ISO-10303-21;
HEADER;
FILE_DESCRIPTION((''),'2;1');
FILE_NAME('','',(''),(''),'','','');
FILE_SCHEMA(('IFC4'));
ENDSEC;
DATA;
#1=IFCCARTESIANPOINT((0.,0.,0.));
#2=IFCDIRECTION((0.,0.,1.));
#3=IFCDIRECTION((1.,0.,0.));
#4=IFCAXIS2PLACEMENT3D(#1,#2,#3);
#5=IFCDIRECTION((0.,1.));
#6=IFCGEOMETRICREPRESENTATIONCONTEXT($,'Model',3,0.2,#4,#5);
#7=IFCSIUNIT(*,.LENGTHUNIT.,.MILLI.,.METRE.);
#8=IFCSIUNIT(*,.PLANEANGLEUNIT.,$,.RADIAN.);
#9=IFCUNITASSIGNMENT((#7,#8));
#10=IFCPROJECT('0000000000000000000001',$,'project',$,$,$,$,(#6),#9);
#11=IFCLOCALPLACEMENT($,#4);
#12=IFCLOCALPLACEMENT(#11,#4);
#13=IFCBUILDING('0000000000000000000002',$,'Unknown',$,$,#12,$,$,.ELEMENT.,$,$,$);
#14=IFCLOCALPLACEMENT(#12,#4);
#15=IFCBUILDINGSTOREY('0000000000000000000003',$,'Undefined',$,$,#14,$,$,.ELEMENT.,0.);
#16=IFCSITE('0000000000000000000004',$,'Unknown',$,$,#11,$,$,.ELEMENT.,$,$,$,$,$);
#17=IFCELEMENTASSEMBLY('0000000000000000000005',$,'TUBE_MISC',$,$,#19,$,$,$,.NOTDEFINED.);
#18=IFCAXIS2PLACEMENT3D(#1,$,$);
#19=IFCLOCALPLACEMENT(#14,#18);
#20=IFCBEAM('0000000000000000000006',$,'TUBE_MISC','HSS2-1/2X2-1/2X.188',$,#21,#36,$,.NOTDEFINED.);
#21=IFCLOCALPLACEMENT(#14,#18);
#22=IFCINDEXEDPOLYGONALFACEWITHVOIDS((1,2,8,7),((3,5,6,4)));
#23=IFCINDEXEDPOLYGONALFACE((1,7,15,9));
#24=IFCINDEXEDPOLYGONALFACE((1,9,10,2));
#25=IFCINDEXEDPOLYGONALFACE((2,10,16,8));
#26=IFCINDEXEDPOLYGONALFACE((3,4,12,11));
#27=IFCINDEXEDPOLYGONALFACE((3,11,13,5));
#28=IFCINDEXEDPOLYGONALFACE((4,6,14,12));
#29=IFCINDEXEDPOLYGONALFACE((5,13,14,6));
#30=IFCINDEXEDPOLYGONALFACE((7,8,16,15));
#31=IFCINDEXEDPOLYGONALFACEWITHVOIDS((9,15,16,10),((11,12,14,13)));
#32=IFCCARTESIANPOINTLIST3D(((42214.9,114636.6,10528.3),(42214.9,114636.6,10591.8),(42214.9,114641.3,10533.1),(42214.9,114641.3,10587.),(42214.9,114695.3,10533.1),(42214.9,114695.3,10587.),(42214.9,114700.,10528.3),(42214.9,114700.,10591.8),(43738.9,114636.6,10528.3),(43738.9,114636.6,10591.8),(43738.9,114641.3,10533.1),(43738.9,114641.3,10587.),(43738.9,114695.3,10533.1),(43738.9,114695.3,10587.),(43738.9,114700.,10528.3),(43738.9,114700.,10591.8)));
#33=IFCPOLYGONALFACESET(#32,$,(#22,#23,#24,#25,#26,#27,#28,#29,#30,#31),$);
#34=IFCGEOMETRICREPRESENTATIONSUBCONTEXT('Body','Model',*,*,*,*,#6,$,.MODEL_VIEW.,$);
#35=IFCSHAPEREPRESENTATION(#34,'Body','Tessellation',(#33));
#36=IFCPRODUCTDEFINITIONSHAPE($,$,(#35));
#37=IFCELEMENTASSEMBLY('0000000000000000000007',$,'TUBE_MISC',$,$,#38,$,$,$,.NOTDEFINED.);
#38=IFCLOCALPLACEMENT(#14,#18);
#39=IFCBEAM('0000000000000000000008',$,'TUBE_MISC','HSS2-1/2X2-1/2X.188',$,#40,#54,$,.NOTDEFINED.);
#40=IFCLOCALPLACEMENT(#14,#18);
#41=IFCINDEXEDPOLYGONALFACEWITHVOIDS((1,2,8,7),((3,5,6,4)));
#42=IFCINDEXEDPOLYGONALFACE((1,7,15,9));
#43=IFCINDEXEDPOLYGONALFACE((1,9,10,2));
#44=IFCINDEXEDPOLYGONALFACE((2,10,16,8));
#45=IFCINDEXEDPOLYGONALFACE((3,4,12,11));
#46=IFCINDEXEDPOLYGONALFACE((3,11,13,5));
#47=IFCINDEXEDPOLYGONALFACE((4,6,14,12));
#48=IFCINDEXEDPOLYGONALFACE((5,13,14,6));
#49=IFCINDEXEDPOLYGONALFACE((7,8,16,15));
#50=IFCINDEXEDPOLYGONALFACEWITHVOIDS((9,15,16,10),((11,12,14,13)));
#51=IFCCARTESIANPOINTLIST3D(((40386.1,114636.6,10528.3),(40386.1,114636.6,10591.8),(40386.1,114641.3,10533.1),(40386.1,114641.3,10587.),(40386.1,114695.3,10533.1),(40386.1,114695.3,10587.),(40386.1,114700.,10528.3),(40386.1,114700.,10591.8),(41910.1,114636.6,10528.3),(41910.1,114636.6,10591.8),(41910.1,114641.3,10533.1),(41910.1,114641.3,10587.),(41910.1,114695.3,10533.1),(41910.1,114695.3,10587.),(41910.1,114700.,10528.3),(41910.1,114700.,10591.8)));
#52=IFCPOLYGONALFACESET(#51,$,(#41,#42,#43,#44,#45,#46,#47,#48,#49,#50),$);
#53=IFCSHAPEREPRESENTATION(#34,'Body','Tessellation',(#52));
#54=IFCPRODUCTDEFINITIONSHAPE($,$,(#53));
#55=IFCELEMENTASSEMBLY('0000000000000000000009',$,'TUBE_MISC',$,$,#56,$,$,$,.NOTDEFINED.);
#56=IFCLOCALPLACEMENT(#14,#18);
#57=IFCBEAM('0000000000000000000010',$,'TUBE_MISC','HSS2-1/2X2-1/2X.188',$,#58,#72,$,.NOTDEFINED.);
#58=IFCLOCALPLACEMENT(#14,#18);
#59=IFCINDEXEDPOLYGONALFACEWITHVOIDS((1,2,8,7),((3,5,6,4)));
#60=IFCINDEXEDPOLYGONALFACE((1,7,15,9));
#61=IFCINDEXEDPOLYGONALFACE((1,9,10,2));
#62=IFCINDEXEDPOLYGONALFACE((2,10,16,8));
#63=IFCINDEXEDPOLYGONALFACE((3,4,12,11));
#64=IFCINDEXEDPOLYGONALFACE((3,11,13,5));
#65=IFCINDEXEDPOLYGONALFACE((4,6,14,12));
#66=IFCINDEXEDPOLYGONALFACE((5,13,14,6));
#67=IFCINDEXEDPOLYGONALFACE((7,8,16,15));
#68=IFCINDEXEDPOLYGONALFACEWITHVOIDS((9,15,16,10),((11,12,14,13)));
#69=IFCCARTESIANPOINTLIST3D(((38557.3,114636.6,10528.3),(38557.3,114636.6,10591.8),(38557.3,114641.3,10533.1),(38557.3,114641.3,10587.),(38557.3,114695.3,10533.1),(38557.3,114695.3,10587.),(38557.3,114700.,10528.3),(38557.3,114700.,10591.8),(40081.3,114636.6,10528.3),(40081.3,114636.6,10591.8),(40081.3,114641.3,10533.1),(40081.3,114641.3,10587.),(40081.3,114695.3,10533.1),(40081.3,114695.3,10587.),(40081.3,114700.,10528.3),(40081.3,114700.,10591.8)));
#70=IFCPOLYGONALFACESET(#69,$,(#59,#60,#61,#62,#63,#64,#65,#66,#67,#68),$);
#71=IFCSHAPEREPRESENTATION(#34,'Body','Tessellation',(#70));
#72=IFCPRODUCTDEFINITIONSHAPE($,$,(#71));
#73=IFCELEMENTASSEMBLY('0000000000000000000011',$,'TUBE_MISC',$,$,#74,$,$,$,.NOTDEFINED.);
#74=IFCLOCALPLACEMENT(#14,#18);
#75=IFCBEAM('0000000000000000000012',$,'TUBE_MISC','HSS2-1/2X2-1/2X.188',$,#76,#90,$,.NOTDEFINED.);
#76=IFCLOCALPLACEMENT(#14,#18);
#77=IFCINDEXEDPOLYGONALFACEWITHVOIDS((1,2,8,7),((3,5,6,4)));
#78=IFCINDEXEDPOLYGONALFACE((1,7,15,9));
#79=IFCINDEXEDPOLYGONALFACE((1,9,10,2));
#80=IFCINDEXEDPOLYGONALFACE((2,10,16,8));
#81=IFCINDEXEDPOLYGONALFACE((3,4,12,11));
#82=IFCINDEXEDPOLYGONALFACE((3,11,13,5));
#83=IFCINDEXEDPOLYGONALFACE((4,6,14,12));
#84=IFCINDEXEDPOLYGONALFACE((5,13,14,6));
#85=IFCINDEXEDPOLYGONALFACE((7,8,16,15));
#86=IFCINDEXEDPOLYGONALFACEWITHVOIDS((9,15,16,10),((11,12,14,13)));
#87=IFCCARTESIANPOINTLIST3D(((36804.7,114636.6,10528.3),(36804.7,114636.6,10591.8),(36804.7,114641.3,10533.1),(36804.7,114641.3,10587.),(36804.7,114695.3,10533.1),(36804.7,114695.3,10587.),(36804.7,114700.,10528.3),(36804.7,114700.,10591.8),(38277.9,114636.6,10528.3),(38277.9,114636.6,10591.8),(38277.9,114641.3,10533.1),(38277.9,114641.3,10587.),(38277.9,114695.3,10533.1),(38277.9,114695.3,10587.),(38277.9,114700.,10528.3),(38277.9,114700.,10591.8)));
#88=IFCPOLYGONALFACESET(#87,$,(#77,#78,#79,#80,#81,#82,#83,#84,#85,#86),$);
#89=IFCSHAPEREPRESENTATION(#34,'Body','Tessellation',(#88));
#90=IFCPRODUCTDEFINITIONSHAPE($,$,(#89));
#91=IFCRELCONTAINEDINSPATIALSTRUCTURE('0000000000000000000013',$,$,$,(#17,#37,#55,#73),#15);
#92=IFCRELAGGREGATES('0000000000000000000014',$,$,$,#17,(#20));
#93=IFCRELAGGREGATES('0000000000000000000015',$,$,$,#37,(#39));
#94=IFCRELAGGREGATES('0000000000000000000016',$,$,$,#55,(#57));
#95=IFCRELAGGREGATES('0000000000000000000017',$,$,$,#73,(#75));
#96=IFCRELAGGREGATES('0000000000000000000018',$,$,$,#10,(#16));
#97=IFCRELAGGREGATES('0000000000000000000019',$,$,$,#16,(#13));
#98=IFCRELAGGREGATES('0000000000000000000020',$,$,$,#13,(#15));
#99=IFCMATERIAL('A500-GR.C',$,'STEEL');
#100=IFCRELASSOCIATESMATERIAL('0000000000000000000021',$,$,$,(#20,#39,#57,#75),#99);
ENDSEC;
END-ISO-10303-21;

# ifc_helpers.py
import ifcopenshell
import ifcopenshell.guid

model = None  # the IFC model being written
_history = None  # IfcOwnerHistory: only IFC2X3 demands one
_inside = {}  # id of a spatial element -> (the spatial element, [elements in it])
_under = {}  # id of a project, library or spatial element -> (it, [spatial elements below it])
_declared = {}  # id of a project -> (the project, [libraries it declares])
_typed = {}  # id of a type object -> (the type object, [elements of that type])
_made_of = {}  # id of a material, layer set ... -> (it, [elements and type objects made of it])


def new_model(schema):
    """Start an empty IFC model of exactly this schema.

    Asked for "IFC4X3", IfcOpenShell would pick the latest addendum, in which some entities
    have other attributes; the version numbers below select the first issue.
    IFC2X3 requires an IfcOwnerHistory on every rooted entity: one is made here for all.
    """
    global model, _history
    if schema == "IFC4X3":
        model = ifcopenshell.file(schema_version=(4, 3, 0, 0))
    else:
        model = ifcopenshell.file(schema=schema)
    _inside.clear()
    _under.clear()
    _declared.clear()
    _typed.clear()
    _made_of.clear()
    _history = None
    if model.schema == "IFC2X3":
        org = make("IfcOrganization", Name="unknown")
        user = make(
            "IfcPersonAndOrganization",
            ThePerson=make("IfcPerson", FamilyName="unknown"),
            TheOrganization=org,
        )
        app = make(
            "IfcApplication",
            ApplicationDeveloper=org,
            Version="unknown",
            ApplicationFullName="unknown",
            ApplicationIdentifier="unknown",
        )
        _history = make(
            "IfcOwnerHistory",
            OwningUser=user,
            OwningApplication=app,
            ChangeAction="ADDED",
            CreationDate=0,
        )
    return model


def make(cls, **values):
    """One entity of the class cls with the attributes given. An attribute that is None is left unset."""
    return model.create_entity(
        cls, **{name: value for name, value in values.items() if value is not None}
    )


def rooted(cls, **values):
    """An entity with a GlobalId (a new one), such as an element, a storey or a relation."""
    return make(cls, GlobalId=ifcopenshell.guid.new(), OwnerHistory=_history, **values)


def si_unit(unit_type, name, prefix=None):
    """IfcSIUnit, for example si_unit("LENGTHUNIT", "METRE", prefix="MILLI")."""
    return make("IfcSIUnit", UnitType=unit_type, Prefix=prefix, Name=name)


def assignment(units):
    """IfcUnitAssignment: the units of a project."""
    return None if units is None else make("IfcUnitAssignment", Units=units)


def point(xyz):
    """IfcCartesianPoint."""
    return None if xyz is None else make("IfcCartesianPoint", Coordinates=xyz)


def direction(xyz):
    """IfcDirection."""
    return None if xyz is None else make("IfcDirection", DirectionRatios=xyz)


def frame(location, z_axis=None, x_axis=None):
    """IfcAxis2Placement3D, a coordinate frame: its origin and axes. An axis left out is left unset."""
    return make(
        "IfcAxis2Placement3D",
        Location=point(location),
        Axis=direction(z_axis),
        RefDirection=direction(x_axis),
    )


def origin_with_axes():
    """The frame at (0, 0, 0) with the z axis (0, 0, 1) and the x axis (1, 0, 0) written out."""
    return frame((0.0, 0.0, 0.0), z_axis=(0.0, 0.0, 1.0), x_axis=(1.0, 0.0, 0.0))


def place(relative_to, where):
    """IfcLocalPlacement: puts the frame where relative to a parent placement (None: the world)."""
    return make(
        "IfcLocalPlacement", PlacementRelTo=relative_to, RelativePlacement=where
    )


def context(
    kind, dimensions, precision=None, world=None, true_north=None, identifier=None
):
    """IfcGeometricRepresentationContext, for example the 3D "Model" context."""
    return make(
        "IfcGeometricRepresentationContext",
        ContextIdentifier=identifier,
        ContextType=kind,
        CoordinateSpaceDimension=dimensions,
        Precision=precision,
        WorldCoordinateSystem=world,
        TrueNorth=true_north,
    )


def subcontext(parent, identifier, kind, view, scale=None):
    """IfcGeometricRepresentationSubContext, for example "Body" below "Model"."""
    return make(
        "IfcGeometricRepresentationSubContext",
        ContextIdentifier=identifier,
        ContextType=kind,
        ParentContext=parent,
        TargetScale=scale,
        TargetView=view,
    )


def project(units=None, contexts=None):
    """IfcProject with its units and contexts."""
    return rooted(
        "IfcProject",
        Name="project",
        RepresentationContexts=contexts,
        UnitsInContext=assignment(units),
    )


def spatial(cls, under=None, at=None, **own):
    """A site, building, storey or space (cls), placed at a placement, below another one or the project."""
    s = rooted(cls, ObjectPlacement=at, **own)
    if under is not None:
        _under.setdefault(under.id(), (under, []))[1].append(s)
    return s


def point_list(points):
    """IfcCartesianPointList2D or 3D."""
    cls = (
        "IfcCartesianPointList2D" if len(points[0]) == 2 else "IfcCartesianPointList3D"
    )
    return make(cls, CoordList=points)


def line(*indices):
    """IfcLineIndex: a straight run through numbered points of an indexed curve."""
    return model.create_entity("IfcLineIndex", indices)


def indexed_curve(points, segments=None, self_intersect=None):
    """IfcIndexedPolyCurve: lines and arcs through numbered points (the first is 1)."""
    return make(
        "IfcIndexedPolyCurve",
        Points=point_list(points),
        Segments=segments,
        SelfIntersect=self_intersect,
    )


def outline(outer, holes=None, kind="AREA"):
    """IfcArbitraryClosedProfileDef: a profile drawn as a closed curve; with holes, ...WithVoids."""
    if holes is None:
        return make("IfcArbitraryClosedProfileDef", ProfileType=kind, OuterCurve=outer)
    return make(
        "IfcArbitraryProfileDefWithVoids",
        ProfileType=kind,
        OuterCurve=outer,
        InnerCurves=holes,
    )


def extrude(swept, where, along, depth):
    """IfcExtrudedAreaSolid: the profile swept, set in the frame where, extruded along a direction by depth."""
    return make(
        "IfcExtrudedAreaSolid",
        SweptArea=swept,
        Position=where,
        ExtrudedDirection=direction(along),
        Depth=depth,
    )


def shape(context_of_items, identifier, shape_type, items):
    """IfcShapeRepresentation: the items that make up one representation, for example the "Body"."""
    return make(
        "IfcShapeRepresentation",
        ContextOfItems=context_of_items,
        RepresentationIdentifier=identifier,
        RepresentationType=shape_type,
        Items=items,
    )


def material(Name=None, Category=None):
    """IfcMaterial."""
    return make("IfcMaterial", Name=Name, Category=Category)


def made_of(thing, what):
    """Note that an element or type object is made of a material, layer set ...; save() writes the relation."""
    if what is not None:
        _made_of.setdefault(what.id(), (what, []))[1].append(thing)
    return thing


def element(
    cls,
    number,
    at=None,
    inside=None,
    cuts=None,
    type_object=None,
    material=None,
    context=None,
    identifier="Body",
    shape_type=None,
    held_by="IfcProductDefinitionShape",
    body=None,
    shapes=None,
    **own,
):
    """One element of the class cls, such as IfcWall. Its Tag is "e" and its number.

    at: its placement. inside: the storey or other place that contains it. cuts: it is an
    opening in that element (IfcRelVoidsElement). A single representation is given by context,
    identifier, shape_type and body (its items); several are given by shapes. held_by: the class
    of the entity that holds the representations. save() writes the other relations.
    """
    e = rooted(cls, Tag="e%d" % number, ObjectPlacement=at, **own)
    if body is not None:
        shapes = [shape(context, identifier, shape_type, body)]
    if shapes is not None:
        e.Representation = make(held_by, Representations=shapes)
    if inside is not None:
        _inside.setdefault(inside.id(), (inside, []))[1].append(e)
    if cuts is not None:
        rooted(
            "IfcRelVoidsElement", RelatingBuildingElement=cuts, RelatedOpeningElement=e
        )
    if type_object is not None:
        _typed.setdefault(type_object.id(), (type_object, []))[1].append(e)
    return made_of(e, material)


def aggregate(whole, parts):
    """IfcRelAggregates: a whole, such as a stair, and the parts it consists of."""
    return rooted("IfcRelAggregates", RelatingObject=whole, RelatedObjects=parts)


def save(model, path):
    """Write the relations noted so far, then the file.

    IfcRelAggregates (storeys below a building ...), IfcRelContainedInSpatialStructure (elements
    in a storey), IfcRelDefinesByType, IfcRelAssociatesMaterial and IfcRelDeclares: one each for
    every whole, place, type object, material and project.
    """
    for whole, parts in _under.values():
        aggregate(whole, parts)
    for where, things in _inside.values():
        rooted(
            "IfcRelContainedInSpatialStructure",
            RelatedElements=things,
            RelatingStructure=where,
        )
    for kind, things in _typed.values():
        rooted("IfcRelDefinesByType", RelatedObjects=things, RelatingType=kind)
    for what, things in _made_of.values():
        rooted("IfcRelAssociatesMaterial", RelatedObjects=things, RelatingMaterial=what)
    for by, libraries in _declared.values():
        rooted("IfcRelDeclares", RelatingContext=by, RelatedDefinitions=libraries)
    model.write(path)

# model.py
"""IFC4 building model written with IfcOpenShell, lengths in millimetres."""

from ifc_helpers import new_model, si_unit, direction, frame, origin_with_axes, place, context, subcontext, project, spatial, line, indexed_curve, outline, extrude, material, element, aggregate, save


model = new_model("IFC4")

# Units and contexts
model_context = context("Model", 3, precision=0.2, world=origin_with_axes(), true_north=direction((0.0, 1.0)))
body_context = subcontext(model_context, "Body", "Model", "MODEL_VIEW")
ifc_project = project(units=[si_unit("LENGTHUNIT", "METRE", prefix="MILLI"), si_unit("PLANEANGLEUNIT", "RADIAN")], contexts=[model_context])

# Site, building, storey
site_placement = place(None, origin_with_axes())
site = spatial("IfcSite", under=ifc_project, at=site_placement, Name="Unknown", CompositionType="ELEMENT")
building_placement = place(site_placement, origin_with_axes())
building = spatial("IfcBuilding", under=site, at=building_placement, Name="Unknown", CompositionType="ELEMENT")
storey_placement = place(building_placement, origin_with_axes())
storey = spatial("IfcBuildingStorey", under=building, at=storey_placement, Name="Undefined", CompositionType="ELEMENT", Elevation=0.0)

# Element assemblies, beams
ifc_material_1 = material(Name="A500-GR.C", Category="STEEL")
assembly_1_placement = place(storey_placement, frame((42214.9, 114668.3, 10560.0), z_axis=(0.0, -1.0, 0.0), x_axis=(1.0, 0.0, 0.0)))
assembly_1 = element("IfcElementAssembly", 1, at=assembly_1_placement, inside=storey, Name="TUBE_MISC", PredefinedType="NOTDEFINED")
beam_1_placement = place(assembly_1_placement, origin_with_axes())
beam_1 = element("IfcBeam", 2, at=beam_1_placement, material=ifc_material_1, Name="TUBE_MISC", Description="HSS2-1/2X2-1/2X.188", PredefinedType="NOTDEFINED", context=body_context, shape_type="SolidModel", body=[
    extrude(outline(indexed_curve([(-31.8, -31.8), (31.8, -31.8), (31.8, 31.8), (-31.8, 31.8)], segments=[line(1, 2, 3, 4, 1)]), holes=[indexed_curve([(-27.0, -27.0), (-27.0, 27.0), (27.0, 27.0), (27.0, -27.0)], segments=[line(1, 2, 3, 4, 1)])]), frame((0.0, 0.0, 0.0), z_axis=(-1.0, 0.0, 0.0), x_axis=(0.0, 0.0, 1.0)), (0.0, 0.0, -1.0), 1524.0),
])
aggregate(assembly_1, [beam_1])
assembly_2_placement = place(storey_placement, frame((40386.1, 114668.3, 10560.0), z_axis=(0.0, -1.0, 0.0), x_axis=(1.0, 0.0, 0.0)))
assembly_2 = element("IfcElementAssembly", 3, at=assembly_2_placement, inside=storey, Name="TUBE_MISC", PredefinedType="NOTDEFINED")
beam_2_placement = place(assembly_2_placement, origin_with_axes())
beam_2 = element("IfcBeam", 4, at=beam_2_placement, material=ifc_material_1, Name="TUBE_MISC", Description="HSS2-1/2X2-1/2X.188", PredefinedType="NOTDEFINED", context=body_context, shape_type="SolidModel", body=[
    extrude(outline(indexed_curve([(-31.8, -31.8), (31.8, -31.8), (31.8, 31.8), (-31.8, 31.8)], segments=[line(1, 2, 3, 4, 1)]), holes=[indexed_curve([(-27.0, -27.0), (-27.0, 27.0), (27.0, 27.0), (27.0, -27.0)], segments=[line(1, 2, 3, 4, 1)])]), frame((0.0, 0.0, 0.0), z_axis=(-1.0, 0.0, 0.0), x_axis=(0.0, 0.0, 1.0)), (0.0, 0.0, -1.0), 1524.0),
])
aggregate(assembly_2, [beam_2])
assembly_3_placement = place(storey_placement, frame((38557.3, 114668.3, 10560.0), z_axis=(0.0, -1.0, 0.0), x_axis=(1.0, 0.0, 0.0)))
assembly_3 = element("IfcElementAssembly", 5, at=assembly_3_placement, inside=storey, Name="TUBE_MISC", PredefinedType="NOTDEFINED")
beam_3_placement = place(assembly_3_placement, origin_with_axes())
beam_3 = element("IfcBeam", 6, at=beam_3_placement, material=ifc_material_1, Name="TUBE_MISC", Description="HSS2-1/2X2-1/2X.188", PredefinedType="NOTDEFINED", context=body_context, shape_type="SolidModel", body=[
    extrude(outline(indexed_curve([(-31.8, -31.8), (31.8, -31.8), (31.8, 31.8), (-31.8, 31.8)], segments=[line(1, 2, 3, 4, 1)]), holes=[indexed_curve([(-27.0, -27.0), (-27.0, 27.0), (27.0, 27.0), (27.0, -27.0)], segments=[line(1, 2, 3, 4, 1)])]), frame((0.0, 0.0, 0.0), z_axis=(-1.0, 0.0, 0.0), x_axis=(0.0, 0.0, 1.0)), (0.0, 0.0, -1.0), 1524.0),
])
aggregate(assembly_3, [beam_3])
assembly_4_placement = place(storey_placement, frame((36804.7, 114668.3, 10560.0), z_axis=(0.0, -1.0, 0.0), x_axis=(1.0, 0.0, 0.0)))
assembly_4 = element("IfcElementAssembly", 7, at=assembly_4_placement, inside=storey, Name="TUBE_MISC", PredefinedType="NOTDEFINED")
beam_4_placement = place(assembly_4_placement, origin_with_axes())
beam_4 = element("IfcBeam", 8, at=beam_4_placement, material=ifc_material_1, Name="TUBE_MISC", Description="HSS2-1/2X2-1/2X.188", PredefinedType="NOTDEFINED", context=body_context, shape_type="SolidModel", body=[
    extrude(outline(indexed_curve([(-31.8, -31.8), (31.8, -31.8), (31.8, 31.8), (-31.8, 31.8)], segments=[line(1, 2, 3, 4, 1)]), holes=[indexed_curve([(-27.0, -27.0), (-27.0, 27.0), (27.0, 27.0), (27.0, -27.0)], segments=[line(1, 2, 3, 4, 1)])]), frame((0.0, 0.0, 0.0), z_axis=(-1.0, 0.0, 0.0), x_axis=(0.0, 0.0, 1.0)), (0.0, 0.0, -1.0), 1473.2),
])
aggregate(assembly_4, [beam_4])

save(model, "model.ifc")
